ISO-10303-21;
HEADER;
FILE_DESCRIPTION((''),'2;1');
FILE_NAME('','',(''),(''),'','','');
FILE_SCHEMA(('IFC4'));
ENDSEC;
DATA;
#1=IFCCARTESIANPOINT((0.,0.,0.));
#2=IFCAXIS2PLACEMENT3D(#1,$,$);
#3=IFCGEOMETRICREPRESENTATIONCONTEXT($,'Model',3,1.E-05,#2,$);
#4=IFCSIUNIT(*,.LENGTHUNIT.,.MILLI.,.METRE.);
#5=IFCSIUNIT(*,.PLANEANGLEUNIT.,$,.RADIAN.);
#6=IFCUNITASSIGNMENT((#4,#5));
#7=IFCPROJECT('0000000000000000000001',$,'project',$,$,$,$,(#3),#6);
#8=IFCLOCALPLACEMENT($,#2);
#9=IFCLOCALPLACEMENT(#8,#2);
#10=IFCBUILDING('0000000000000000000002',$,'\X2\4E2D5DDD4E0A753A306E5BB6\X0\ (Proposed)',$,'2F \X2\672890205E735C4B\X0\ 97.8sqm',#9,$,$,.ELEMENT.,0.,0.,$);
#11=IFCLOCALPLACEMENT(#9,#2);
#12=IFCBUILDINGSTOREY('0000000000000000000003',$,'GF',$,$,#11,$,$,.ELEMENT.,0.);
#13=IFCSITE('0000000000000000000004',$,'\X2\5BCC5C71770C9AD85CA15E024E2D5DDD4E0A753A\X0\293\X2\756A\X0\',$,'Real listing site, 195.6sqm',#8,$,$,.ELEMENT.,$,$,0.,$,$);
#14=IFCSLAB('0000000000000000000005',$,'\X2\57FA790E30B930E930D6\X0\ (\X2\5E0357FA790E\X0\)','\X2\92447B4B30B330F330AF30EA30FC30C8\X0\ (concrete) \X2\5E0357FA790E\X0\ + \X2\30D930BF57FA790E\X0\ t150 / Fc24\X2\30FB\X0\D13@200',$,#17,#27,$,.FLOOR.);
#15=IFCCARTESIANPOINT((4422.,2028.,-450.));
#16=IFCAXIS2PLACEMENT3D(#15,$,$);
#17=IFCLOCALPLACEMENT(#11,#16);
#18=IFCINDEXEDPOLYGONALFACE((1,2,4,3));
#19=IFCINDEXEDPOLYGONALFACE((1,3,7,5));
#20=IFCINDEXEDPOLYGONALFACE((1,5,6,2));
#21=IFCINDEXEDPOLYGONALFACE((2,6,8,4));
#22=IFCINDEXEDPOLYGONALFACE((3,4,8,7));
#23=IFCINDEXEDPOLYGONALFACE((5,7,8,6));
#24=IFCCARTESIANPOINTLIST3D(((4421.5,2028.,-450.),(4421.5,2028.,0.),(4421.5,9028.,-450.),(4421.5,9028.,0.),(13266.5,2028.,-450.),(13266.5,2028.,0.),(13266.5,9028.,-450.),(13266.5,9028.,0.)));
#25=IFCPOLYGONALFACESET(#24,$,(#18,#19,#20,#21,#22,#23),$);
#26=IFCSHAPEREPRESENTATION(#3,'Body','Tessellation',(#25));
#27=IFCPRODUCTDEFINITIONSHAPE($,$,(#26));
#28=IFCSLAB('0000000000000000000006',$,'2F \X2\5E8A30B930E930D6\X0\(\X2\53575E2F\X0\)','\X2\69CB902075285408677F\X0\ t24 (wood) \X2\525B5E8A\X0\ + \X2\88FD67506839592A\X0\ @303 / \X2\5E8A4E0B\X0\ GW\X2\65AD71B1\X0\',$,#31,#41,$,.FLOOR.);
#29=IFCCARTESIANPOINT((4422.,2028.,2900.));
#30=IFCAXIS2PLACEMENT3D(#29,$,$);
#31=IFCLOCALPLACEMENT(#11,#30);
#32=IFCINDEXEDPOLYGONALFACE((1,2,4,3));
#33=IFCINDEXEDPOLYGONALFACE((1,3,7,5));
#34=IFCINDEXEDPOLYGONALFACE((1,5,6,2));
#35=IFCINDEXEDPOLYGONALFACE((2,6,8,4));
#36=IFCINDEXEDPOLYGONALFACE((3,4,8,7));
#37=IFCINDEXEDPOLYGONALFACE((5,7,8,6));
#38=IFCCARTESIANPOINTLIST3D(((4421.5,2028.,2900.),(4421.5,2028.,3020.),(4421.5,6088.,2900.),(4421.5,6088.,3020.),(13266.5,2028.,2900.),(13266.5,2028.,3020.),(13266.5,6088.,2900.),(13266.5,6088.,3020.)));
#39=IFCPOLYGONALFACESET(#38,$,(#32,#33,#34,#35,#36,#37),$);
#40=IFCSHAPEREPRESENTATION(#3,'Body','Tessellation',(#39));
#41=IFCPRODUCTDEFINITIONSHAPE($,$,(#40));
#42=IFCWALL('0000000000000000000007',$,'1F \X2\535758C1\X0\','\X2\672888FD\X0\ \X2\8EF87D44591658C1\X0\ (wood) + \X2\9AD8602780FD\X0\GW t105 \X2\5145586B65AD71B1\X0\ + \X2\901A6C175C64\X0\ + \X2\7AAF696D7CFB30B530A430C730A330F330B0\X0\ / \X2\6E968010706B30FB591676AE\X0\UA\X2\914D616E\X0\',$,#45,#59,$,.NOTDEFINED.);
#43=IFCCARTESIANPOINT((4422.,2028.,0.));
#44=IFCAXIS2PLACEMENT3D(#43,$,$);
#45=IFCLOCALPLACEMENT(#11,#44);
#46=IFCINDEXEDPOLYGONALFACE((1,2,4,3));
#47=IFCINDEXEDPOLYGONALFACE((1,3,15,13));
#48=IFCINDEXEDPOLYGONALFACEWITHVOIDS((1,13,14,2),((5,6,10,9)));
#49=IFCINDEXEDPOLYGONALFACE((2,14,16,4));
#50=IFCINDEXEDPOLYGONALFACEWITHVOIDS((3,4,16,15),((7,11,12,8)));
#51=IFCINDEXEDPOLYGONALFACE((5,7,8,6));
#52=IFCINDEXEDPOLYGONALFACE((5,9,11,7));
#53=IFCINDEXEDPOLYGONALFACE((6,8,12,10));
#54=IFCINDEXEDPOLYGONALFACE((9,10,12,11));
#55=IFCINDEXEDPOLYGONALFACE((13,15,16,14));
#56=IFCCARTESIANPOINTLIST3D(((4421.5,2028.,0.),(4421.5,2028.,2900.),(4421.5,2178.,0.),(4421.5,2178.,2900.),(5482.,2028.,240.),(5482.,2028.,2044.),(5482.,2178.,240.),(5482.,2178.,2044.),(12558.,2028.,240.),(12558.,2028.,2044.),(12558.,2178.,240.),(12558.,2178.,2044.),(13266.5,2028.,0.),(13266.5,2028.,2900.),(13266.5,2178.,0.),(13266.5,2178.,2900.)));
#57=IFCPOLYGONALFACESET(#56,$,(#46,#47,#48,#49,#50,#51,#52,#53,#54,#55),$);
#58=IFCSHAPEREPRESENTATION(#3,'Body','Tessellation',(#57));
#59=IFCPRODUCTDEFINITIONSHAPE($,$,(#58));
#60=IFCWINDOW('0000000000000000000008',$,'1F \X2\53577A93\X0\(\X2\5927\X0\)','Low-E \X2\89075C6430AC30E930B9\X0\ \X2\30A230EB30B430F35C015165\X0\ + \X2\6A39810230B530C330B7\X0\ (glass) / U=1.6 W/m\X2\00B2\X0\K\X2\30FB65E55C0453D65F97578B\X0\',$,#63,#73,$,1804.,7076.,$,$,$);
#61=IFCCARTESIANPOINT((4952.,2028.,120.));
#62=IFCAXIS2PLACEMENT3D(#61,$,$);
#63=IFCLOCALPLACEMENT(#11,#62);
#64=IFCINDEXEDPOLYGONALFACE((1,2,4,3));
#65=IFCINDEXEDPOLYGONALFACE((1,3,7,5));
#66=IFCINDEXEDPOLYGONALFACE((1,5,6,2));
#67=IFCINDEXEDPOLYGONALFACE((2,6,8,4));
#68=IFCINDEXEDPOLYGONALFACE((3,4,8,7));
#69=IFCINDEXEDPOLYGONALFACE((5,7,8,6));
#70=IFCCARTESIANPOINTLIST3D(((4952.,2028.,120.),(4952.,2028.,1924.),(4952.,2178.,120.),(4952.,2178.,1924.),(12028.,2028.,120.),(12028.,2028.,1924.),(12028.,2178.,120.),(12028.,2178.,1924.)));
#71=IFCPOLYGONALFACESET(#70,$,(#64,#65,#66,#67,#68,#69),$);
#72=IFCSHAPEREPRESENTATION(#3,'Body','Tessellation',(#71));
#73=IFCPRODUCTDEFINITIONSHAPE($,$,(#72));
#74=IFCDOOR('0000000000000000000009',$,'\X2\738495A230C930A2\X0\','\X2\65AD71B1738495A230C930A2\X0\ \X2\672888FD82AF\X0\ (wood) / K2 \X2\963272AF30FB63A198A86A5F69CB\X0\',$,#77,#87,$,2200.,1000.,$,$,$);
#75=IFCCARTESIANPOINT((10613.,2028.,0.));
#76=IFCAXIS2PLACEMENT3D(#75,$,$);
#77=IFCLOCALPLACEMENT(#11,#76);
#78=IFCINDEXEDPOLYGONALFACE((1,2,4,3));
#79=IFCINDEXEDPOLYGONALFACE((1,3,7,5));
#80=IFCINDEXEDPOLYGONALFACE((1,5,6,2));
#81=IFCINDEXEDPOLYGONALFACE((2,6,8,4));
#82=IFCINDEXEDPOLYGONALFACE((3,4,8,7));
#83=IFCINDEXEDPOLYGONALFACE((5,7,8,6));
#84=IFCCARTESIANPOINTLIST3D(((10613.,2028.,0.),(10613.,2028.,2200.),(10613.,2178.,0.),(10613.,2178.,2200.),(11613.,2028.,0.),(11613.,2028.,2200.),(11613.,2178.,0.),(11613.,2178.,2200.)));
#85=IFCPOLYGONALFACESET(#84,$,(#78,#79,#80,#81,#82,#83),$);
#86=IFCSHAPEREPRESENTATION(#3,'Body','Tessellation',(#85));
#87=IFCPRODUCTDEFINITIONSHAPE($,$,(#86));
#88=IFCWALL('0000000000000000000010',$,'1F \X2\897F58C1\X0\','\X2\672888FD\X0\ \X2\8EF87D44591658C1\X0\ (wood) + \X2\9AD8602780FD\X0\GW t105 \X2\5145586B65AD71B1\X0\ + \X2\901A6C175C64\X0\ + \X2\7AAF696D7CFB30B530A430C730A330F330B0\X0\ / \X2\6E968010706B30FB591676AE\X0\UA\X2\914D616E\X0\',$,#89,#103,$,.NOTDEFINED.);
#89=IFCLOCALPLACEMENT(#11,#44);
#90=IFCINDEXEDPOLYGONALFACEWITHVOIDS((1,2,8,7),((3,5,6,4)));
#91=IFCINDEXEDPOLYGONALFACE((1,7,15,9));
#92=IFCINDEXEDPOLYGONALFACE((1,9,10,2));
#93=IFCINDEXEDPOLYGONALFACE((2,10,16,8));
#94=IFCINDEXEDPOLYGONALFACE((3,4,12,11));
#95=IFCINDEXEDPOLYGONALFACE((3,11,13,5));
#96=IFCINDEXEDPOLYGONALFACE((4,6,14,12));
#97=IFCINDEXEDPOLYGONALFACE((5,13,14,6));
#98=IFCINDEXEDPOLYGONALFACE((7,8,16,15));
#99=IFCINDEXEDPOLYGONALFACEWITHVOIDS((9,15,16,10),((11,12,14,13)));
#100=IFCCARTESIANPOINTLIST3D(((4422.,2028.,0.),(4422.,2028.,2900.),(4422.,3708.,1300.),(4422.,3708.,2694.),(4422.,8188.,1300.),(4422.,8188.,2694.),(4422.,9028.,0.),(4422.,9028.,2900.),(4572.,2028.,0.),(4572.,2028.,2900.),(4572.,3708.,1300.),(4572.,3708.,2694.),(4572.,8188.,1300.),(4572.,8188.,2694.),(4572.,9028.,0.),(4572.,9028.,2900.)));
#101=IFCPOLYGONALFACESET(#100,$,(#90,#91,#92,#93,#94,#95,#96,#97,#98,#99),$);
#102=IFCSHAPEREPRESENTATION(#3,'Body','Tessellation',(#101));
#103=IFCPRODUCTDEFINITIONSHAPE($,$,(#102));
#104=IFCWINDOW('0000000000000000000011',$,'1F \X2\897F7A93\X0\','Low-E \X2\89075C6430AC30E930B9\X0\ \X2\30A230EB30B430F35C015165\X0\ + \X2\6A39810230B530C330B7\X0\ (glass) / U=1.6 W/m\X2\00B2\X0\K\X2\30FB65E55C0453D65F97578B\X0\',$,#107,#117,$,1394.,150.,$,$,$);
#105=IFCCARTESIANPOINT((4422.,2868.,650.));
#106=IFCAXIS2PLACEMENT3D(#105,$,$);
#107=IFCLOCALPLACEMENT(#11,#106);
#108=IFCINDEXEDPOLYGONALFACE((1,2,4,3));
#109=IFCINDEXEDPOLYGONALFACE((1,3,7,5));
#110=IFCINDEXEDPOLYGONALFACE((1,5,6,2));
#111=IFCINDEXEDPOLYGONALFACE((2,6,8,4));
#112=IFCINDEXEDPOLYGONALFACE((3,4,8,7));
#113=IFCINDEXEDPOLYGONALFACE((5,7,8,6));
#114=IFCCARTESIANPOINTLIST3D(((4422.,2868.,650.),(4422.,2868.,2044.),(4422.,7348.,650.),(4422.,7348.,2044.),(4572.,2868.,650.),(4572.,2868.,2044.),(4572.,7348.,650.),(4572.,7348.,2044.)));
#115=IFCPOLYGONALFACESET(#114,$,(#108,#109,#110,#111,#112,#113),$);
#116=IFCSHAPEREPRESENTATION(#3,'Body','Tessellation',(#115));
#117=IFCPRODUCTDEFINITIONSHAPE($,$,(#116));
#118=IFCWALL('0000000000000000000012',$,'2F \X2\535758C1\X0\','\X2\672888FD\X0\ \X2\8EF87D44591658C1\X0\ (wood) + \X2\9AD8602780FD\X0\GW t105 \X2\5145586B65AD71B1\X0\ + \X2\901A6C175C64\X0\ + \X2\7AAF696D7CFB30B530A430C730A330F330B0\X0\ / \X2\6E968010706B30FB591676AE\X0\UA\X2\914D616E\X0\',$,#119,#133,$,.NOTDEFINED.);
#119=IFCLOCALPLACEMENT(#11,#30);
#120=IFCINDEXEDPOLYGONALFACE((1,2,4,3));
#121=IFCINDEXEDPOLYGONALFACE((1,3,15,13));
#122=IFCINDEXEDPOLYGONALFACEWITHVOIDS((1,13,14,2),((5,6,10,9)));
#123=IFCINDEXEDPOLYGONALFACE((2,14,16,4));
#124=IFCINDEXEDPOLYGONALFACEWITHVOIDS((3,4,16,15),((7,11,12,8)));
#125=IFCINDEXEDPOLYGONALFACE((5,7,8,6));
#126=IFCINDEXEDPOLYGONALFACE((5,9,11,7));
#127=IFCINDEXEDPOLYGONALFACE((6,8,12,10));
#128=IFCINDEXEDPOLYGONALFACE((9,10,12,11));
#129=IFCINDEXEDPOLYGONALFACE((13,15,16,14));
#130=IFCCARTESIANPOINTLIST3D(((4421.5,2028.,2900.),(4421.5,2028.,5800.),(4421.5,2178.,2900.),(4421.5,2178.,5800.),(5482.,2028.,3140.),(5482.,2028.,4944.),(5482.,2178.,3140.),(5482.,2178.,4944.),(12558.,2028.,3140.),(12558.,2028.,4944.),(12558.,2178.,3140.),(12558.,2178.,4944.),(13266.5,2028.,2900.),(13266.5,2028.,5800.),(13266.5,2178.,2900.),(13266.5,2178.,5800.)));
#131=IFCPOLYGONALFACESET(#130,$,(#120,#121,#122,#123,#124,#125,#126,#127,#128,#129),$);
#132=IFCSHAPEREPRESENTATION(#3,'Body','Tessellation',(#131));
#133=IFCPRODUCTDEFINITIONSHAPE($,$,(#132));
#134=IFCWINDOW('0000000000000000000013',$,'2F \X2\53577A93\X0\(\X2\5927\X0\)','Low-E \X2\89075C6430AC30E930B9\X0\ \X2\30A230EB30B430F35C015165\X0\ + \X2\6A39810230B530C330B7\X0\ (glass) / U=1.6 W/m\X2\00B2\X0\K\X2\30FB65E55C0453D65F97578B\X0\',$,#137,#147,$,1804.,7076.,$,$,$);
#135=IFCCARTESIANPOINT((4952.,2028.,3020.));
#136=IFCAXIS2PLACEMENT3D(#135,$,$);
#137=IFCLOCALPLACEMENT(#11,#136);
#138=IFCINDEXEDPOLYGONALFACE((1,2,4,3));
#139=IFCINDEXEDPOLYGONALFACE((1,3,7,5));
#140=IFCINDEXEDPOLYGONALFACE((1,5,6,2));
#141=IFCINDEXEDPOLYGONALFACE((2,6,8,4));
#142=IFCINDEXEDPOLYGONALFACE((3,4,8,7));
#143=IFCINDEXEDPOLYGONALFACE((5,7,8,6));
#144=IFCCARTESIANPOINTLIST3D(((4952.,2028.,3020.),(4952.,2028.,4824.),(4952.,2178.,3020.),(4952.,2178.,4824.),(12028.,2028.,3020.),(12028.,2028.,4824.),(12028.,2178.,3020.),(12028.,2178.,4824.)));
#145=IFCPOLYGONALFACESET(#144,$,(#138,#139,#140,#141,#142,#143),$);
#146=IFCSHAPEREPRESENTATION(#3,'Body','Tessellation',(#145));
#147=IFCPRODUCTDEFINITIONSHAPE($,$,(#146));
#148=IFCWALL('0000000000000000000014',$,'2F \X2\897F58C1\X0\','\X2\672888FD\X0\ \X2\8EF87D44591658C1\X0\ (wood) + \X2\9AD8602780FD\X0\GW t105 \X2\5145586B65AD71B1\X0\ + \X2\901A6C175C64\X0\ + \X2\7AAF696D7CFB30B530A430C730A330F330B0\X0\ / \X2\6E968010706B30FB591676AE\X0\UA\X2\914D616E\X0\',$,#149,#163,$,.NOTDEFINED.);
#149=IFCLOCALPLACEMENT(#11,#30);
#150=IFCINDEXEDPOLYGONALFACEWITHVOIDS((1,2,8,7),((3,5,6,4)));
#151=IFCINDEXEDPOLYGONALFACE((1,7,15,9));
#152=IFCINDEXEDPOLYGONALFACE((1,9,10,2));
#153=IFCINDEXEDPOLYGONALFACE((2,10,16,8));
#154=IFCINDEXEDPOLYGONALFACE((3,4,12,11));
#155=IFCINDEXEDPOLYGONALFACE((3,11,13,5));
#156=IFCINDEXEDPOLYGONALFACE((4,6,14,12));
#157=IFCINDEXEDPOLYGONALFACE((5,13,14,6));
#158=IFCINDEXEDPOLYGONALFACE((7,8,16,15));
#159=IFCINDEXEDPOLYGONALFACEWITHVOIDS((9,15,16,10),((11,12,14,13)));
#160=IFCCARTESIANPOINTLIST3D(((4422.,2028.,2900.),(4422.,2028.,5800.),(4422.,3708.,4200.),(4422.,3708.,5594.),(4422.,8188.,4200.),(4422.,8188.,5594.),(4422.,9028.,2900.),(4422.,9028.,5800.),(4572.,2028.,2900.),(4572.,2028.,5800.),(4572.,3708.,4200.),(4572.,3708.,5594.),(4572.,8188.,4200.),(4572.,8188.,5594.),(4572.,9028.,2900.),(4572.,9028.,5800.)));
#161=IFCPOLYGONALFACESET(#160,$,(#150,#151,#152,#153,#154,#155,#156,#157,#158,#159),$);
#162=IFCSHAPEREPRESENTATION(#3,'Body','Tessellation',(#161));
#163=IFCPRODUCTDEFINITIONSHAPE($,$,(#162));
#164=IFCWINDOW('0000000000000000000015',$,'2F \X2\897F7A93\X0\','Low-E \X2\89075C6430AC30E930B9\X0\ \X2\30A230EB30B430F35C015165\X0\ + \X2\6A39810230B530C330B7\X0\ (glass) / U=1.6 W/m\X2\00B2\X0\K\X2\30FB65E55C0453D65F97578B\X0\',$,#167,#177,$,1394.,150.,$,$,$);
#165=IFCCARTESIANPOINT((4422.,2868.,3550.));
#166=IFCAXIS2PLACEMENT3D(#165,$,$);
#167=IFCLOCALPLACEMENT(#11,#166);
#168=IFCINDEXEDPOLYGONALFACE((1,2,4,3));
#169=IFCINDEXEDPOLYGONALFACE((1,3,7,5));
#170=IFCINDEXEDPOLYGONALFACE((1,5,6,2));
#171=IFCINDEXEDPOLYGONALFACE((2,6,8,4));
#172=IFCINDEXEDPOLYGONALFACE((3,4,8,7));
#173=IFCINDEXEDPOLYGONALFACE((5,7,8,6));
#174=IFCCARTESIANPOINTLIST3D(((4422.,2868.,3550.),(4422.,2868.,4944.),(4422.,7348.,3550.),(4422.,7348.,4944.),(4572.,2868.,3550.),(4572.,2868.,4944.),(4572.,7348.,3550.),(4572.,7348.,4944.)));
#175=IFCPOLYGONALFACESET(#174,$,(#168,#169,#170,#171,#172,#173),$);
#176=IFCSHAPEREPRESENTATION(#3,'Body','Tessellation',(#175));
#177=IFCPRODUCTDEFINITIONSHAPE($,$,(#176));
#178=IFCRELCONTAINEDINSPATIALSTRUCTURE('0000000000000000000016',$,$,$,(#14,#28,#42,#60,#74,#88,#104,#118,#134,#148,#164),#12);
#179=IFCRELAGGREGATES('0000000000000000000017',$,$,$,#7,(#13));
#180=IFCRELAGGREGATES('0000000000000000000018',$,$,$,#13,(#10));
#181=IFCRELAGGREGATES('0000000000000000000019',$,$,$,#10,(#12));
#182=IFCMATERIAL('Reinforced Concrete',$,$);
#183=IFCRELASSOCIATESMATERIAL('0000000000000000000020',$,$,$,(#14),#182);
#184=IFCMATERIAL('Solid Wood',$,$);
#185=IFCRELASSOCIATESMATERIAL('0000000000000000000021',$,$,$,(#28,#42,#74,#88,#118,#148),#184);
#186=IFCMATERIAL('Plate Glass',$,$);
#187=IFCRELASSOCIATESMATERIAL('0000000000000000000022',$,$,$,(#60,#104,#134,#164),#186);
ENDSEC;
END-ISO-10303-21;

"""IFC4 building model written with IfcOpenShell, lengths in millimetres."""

from ifc_helpers import new_model, si_unit, frame, frame_2d, origin, place, context, project, spatial, rectangle, extrude, material, element, fill, save


model = new_model("IFC4")

# Units and contexts
model_context = context("Model", 3, precision=1e-05, world=origin())
ifc_project = project(units=[si_unit("LENGTHUNIT", "METRE", prefix="MILLI"), si_unit("PLANEANGLEUNIT", "RADIAN")], contexts=[model_context])

# Site, building, storey
site_placement = place(None, origin())
site = spatial("IfcSite", under=ifc_project, at=site_placement, Name="富山県高岡市中川上町293番", ObjectType="Real listing site, 195.6sqm", CompositionType="ELEMENT", RefElevation=0.0)
building_placement = place(site_placement, origin())
building = spatial("IfcBuilding", under=site, at=building_placement, Name="中川上町の家 (Proposed)", ObjectType="2F 木造平屋 97.8sqm", CompositionType="ELEMENT", ElevationOfRefHeight=0.0, ElevationOfTerrain=0.0)
storey_placement = place(building_placement, origin())
storey = spatial("IfcBuildingStorey", under=building, at=storey_placement, Name="GF", CompositionType="ELEMENT", Elevation=0.0)

# Slabs
ifc_material_1 = material(Name="Reinforced Concrete")
slab_1_placement = place(storey_placement, frame((4422.0, 2028.0, -450.0)))
element("IfcSlab", 1, at=slab_1_placement, inside=storey, material=ifc_material_1, Name="基礎スラブ (布基礎)", Description="鉄筋コンクリート (concrete) 布基礎 + ベタ基礎 t150 / Fc24・D13@200", PredefinedType="FLOOR", context=model_context, shape_type="SweptSolid", body=[
    extrude(rectangle(XDim=8845.0, YDim=7000.0, at=frame_2d((4422.0, 3500.0))), frame((4422.0, 2028.0, -450.0)), (0.0, 0.0, 1.0), 450.0),
])
ifc_material_2 = material(Name="Solid Wood")
slab_2_placement = place(storey_placement, frame((4422.0, 2028.0, 2900.0)))
element("IfcSlab", 2, at=slab_2_placement, inside=storey, material=ifc_material_2, Name="2F 床スラブ(南帯)", Description="構造用合板 t24 (wood) 剛床 + 製材根太 @303 / 床下 GW断熱", PredefinedType="FLOOR", context=model_context, shape_type="SweptSolid", body=[
    extrude(rectangle(XDim=8845.0, YDim=4060.0, at=frame_2d((4422.0, 2030.0))), frame((4422.0, 2028.0, 2900.0)), (0.0, 0.0, 1.0), 120.0),
])

# Wall, openings, window, door
wall_1_placement = place(storey_placement, frame((4422.0, 2028.0, 0.0)))
wall_1 = element("IfcWall", 3, at=wall_1_placement, inside=storey, material=ifc_material_2, Name="1F 南壁", Description="木製 軸組外壁 (wood) + 高性能GW t105 充填断熱 + 通気層 + 窯業系サイディング / 準耐火・外皮UA配慮", PredefinedType="NOTDEFINED", context=model_context, shape_type="SweptSolid", body=[
    extrude(rectangle(XDim=8845.0, YDim=150.0, at=frame_2d((4422.0, 75.0))), frame((4422.0, 2028.0, 0.0)), (0.0, 0.0, 1.0), 2900.0),
])
opening_1_placement = place(storey_placement, frame((4952.0, 2028.0, 120.0)))
opening_1 = element("IfcOpeningElement", 4, at=opening_1_placement, cuts=wall_1, PredefinedType="NOTDEFINED", context=model_context, shape_type="SweptSolid", body=[
    extrude(rectangle(XDim=7076.0, YDim=150.0, at=frame_2d((3538.0, 75.0))), frame((4952.0, 2028.0, 120.0)), (0.0, 0.0, 1.0), 1804.0),
])
opening_2_placement = place(storey_placement, frame((10613.0, 2028.0, 0.0)))
opening_2 = element("IfcOpeningElement", 5, at=opening_2_placement, cuts=wall_1, PredefinedType="NOTDEFINED", context=model_context, shape_type="SweptSolid", body=[
    extrude(rectangle(XDim=1000.0, YDim=150.0, at=frame_2d((500.0, 75.0))), frame((10613.0, 2028.0, 0.0)), (0.0, 0.0, 1.0), 2200.0),
])
ifc_material_3 = material(Name="Plate Glass")
window_1_placement = place(storey_placement, frame((4952.0, 2028.0, 120.0)))
window_1 = element("IfcWindow", 6, at=window_1_placement, inside=storey, material=ifc_material_3, Name="1F 南窓(大)", Description="Low-E 複層ガラス アルゴン封入 + 樹脂サッシ (glass) / U=1.6 W/m²K・日射取得型", OverallHeight=1804.0, OverallWidth=7076.0, context=model_context, shape_type="SweptSolid", body=[
    extrude(rectangle(XDim=7076.0, YDim=150.0, at=frame_2d((3538.0, 75.0))), frame((4952.0, 2028.0, 120.0)), (0.0, 0.0, 1.0), 1804.0),
])
fill(opening_1, window_1)
door_placement = place(storey_placement, frame((10613.0, 2028.0, 0.0)))
door = element("IfcDoor", 7, at=door_placement, inside=storey, material=ifc_material_2, Name="玄関ドア", Description="断熱玄関ドア 木製芯 (wood) / K2 防犯・採風機構", OverallHeight=2200.0, OverallWidth=1000.0, context=model_context, shape_type="SweptSolid", body=[
    extrude(rectangle(XDim=1000.0, YDim=150.0, at=frame_2d((500.0, 75.0))), frame((10613.0, 2028.0, 0.0)), (0.0, 0.0, 1.0), 2200.0),
])
fill(opening_2, door)

# Wall, opening, window
wall_2_placement = place(storey_placement, frame((4422.0, 2028.0, 0.0)))
wall_2 = element("IfcWall", 8, at=wall_2_placement, inside=storey, material=ifc_material_2, Name="1F 西壁", Description="木製 軸組外壁 (wood) + 高性能GW t105 充填断熱 + 通気層 + 窯業系サイディング / 準耐火・外皮UA配慮", PredefinedType="NOTDEFINED", context=model_context, shape_type="SweptSolid", body=[
    extrude(rectangle(XDim=150.0, YDim=7000.0, at=frame_2d((75.0, 3500.0))), frame((4422.0, 2028.0, 0.0)), (0.0, 0.0, 1.0), 2900.0),
])
opening_3_placement = place(storey_placement, frame((4422.0, 2868.0, 650.0)))
opening_3 = element("IfcOpeningElement", 9, at=opening_3_placement, cuts=wall_2, PredefinedType="NOTDEFINED", context=model_context, shape_type="SweptSolid", body=[
    extrude(rectangle(XDim=150.0, YDim=4480.0, at=frame_2d((75.0, 2240.0))), frame((4422.0, 2868.0, 650.0)), (0.0, 0.0, 1.0), 1394.0),
])
window_2_placement = place(storey_placement, frame((4422.0, 2868.0, 650.0)))
window_2 = element("IfcWindow", 10, at=window_2_placement, inside=storey, material=ifc_material_3, Name="1F 西窓", Description="Low-E 複層ガラス アルゴン封入 + 樹脂サッシ (glass) / U=1.6 W/m²K・日射取得型", OverallHeight=1394.0, OverallWidth=150.0, context=model_context, shape_type="SweptSolid", body=[
    extrude(rectangle(XDim=150.0, YDim=4480.0, at=frame_2d((75.0, 2240.0))), frame((4422.0, 2868.0, 650.0)), (0.0, 0.0, 1.0), 1394.0),
])
fill(opening_3, window_2)

# Walls, openings, windows
wall_3_placement = place(storey_placement, frame((4422.0, 2028.0, 2900.0)))
wall_3 = element("IfcWall", 11, at=wall_3_placement, inside=storey, material=ifc_material_2, Name="2F 南壁", Description="木製 軸組外壁 (wood) + 高性能GW t105 充填断熱 + 通気層 + 窯業系サイディング / 準耐火・外皮UA配慮", PredefinedType="NOTDEFINED", context=model_context, shape_type="SweptSolid", body=[
    extrude(rectangle(XDim=8845.0, YDim=150.0, at=frame_2d((4422.0, 75.0))), frame((4422.0, 2028.0, 2900.0)), (0.0, 0.0, 1.0), 2900.0),
])
opening_4_placement = place(storey_placement, frame((4952.0, 2028.0, 3020.0)))
opening_4 = element("IfcOpeningElement", 12, at=opening_4_placement, cuts=wall_3, PredefinedType="NOTDEFINED", context=model_context, shape_type="SweptSolid", body=[
    extrude(rectangle(XDim=7076.0, YDim=150.0, at=frame_2d((3538.0, 75.0))), frame((4952.0, 2028.0, 3020.0)), (0.0, 0.0, 1.0), 1804.0),
])
window_3_placement = place(storey_placement, frame((4952.0, 2028.0, 3020.0)))
window_3 = element("IfcWindow", 13, at=window_3_placement, inside=storey, material=ifc_material_3, Name="2F 南窓(大)", Description="Low-E 複層ガラス アルゴン封入 + 樹脂サッシ (glass) / U=1.6 W/m²K・日射取得型", OverallHeight=1804.0, OverallWidth=7076.0, context=model_context, shape_type="SweptSolid", body=[
    extrude(rectangle(XDim=7076.0, YDim=150.0, at=frame_2d((3538.0, 75.0))), frame((4952.0, 2028.0, 3020.0)), (0.0, 0.0, 1.0), 1804.0),
])
fill(opening_4, window_3)
wall_4_placement = place(storey_placement, frame((4422.0, 2028.0, 2900.0)))
wall_4 = element("IfcWall", 14, at=wall_4_placement, inside=storey, material=ifc_material_2, Name="2F 西壁", Description="木製 軸組外壁 (wood) + 高性能GW t105 充填断熱 + 通気層 + 窯業系サイディング / 準耐火・外皮UA配慮", PredefinedType="NOTDEFINED", context=model_context, shape_type="SweptSolid", body=[
    extrude(rectangle(XDim=150.0, YDim=7000.0, at=frame_2d((75.0, 3500.0))), frame((4422.0, 2028.0, 2900.0)), (0.0, 0.0, 1.0), 2900.0),
])
opening_5_placement = place(storey_placement, frame((4422.0, 2868.0, 3550.0)))
opening_5 = element("IfcOpeningElement", 15, at=opening_5_placement, cuts=wall_4, PredefinedType="NOTDEFINED", context=model_context, shape_type="SweptSolid", body=[
    extrude(rectangle(XDim=150.0, YDim=4480.0, at=frame_2d((75.0, 2240.0))), frame((4422.0, 2868.0, 3550.0)), (0.0, 0.0, 1.0), 1394.0),
])
window_4_placement = place(storey_placement, frame((4422.0, 2868.0, 3550.0)))
window_4 = element("IfcWindow", 16, at=window_4_placement, inside=storey, material=ifc_material_3, Name="2F 西窓", Description="Low-E 複層ガラス アルゴン封入 + 樹脂サッシ (glass) / U=1.6 W/m²K・日射取得型", OverallHeight=1394.0, OverallWidth=150.0, context=model_context, shape_type="SweptSolid", body=[
    extrude(rectangle(XDim=150.0, YDim=4480.0, at=frame_2d((75.0, 2240.0))), frame((4422.0, 2868.0, 3550.0)), (0.0, 0.0, 1.0), 1394.0),
])
fill(opening_5, window_4)

save(model, "model.ifc")
